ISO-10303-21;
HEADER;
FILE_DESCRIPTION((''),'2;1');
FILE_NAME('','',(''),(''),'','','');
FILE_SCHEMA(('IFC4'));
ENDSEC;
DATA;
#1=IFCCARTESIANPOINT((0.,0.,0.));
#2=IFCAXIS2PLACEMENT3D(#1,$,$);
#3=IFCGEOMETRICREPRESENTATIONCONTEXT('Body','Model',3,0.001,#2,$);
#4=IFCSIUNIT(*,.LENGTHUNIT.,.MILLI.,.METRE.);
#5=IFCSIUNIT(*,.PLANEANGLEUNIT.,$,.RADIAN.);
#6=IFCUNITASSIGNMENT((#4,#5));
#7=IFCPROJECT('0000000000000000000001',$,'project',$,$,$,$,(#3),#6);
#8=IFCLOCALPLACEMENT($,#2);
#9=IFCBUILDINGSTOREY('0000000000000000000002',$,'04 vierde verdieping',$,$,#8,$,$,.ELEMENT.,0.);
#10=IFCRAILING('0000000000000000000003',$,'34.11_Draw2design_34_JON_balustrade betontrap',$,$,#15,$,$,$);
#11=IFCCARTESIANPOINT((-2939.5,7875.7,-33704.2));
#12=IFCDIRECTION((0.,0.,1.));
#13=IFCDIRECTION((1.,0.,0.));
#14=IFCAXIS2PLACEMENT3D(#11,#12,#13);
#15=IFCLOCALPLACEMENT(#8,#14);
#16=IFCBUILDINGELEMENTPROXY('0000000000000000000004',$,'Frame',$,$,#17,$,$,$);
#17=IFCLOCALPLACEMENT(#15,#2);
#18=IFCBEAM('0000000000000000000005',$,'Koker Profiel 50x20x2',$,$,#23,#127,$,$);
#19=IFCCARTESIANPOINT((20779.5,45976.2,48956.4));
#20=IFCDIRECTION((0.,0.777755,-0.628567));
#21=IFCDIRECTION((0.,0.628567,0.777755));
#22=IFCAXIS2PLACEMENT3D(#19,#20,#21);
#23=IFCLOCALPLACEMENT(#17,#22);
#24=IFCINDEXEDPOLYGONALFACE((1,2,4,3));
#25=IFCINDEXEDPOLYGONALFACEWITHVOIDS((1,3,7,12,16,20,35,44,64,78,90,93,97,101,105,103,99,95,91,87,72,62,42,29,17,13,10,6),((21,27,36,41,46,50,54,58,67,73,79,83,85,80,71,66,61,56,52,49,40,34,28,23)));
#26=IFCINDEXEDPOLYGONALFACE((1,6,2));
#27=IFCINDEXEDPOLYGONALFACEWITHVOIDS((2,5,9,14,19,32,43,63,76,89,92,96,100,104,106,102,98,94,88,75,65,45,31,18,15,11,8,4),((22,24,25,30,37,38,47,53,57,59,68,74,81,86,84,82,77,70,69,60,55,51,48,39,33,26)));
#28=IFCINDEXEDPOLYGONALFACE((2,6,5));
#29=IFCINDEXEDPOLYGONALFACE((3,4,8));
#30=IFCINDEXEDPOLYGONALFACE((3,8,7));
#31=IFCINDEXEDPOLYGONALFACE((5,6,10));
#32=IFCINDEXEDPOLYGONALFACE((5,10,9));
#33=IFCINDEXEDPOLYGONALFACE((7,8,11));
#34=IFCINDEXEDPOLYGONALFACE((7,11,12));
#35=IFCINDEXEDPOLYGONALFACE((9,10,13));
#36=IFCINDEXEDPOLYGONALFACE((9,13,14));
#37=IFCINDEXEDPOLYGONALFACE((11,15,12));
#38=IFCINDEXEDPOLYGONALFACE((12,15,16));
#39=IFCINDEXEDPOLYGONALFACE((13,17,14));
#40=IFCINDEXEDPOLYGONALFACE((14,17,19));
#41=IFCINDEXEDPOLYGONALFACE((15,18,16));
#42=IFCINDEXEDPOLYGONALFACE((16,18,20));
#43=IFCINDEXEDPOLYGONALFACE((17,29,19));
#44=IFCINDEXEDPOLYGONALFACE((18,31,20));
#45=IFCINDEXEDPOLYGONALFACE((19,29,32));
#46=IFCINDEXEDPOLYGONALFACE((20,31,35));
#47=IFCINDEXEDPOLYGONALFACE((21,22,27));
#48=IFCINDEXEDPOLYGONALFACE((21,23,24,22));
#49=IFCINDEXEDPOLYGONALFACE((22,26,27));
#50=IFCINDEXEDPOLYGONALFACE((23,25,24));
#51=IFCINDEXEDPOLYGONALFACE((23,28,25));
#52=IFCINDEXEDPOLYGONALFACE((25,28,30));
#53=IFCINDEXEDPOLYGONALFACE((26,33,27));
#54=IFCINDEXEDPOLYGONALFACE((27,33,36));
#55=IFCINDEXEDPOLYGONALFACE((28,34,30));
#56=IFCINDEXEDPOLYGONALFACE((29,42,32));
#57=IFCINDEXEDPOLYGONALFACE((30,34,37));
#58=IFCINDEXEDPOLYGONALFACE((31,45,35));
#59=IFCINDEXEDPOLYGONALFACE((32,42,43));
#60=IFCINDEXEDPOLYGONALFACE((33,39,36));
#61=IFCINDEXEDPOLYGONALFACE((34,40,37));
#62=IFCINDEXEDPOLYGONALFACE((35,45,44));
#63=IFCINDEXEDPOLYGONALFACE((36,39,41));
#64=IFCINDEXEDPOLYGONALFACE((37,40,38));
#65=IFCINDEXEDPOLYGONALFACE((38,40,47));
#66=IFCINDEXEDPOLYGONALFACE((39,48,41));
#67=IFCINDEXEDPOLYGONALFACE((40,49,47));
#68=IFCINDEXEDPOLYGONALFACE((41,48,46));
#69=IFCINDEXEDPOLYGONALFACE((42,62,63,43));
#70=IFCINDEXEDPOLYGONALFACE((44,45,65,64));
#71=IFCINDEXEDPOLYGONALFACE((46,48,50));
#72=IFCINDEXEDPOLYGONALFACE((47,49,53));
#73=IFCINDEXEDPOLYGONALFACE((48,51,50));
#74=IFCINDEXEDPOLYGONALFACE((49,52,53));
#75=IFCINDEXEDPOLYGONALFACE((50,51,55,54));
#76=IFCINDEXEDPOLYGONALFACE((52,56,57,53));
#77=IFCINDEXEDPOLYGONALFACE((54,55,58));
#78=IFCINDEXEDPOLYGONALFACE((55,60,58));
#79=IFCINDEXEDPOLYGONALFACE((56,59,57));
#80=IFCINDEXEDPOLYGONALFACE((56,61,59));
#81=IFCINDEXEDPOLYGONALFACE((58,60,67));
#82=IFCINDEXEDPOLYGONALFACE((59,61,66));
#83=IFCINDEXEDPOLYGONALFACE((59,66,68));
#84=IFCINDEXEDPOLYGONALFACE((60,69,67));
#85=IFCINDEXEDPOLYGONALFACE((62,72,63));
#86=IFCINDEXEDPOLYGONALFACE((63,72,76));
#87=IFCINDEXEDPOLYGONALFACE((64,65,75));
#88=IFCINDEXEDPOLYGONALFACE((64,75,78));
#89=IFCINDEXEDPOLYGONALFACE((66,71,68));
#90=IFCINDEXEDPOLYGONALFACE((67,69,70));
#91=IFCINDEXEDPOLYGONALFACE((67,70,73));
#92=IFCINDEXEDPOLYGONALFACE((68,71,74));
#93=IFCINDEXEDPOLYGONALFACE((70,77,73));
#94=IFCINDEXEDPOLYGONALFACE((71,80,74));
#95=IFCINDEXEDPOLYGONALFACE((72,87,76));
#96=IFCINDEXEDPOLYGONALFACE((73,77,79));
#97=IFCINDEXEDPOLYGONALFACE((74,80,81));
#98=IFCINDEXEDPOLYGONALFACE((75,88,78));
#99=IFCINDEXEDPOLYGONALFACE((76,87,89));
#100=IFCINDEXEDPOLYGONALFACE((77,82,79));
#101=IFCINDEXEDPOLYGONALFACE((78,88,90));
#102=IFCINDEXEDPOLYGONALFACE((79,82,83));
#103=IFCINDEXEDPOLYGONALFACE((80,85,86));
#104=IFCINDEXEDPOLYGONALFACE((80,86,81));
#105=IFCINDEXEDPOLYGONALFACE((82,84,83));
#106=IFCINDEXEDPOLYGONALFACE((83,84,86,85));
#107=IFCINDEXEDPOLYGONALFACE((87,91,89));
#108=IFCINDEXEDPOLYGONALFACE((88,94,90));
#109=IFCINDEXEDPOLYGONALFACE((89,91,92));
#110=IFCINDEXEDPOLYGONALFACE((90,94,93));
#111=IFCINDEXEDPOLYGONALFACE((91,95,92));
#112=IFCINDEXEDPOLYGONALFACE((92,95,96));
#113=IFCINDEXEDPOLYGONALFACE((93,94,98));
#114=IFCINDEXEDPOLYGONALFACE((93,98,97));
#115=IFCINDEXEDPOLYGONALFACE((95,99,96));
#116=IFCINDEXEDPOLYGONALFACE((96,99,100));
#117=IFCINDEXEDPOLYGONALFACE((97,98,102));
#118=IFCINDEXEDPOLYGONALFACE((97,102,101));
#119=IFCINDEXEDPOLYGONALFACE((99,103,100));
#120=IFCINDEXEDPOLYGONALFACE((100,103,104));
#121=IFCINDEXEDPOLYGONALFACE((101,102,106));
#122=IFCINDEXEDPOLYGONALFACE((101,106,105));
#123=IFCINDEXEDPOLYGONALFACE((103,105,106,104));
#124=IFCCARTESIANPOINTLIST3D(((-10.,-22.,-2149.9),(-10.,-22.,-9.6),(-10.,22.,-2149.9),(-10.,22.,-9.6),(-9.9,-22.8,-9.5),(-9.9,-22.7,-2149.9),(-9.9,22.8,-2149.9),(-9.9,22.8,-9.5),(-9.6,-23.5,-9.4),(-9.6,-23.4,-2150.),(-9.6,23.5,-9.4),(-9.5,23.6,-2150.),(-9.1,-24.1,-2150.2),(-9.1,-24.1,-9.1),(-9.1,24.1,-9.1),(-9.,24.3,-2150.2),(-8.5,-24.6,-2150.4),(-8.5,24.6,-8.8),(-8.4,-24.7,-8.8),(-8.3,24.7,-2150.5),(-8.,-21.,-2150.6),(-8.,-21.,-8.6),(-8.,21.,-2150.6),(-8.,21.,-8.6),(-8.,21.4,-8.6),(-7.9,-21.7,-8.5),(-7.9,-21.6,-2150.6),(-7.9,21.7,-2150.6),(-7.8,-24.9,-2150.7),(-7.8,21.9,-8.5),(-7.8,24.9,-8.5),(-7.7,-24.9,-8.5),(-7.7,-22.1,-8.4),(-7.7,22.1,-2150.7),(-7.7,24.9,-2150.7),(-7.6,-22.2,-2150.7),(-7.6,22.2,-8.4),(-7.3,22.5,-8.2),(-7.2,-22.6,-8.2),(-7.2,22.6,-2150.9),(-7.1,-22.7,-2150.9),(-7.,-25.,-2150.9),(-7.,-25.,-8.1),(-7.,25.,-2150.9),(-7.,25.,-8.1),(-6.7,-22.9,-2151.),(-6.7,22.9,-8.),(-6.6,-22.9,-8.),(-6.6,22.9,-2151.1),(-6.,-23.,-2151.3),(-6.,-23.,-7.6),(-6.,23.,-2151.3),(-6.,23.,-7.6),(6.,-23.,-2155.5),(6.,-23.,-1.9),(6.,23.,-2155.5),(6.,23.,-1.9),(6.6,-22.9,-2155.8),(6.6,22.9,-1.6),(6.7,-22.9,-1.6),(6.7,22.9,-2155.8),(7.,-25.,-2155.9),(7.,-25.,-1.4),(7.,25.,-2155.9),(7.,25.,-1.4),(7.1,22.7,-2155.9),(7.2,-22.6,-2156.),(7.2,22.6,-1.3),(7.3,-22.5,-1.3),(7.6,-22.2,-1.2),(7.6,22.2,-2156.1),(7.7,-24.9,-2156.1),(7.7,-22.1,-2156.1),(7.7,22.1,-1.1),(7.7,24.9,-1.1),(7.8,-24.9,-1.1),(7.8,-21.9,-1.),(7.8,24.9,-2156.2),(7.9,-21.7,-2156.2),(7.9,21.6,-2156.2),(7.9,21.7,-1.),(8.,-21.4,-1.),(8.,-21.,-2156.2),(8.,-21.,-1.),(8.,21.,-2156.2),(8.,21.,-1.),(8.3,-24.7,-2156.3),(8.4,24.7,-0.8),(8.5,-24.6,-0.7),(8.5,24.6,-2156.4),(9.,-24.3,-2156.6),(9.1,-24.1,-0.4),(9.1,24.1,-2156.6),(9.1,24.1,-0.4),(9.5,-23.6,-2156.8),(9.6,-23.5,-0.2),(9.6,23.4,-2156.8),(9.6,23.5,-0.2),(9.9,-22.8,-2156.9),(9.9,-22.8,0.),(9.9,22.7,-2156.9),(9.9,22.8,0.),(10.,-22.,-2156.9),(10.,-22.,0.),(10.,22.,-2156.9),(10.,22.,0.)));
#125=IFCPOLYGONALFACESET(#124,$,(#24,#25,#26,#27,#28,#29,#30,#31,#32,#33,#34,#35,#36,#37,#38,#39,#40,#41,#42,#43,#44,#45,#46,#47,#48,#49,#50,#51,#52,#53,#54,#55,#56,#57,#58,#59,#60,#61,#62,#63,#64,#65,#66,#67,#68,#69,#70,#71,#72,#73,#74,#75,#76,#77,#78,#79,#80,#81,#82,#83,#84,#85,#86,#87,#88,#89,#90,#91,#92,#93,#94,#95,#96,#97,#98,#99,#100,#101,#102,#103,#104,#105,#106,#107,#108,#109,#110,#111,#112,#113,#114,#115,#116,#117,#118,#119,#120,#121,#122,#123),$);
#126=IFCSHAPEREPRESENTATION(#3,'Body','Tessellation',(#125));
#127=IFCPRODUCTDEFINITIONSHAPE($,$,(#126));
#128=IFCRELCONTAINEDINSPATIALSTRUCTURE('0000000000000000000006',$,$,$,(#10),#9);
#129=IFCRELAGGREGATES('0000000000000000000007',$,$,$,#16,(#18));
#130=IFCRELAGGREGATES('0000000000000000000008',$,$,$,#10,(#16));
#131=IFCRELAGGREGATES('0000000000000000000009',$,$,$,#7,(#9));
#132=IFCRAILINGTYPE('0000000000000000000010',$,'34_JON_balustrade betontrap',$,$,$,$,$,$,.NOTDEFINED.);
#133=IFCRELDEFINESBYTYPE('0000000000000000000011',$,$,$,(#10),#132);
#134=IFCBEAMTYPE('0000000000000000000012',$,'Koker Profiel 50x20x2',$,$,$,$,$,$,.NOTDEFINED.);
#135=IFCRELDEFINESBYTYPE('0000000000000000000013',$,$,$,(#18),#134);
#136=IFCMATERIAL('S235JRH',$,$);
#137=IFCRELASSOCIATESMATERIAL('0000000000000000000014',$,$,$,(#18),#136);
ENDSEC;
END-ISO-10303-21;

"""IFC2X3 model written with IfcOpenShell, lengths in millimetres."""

from ifc_helpers import new_model, si_unit, frame, origin, origin_2d, place, context, project, spatial, hollow_rectangle, extrude, clip, halfspace, source, transform, mapped, material, type_object, element, aggregate, save


model = new_model("IFC2X3")

# Units and contexts
model_context = context("Model", 3, precision=0.001, world=origin(), identifier="Body")
ifc_project = project(units=[si_unit("LENGTHUNIT", "METRE", prefix="MILLI"), si_unit("PLANEANGLEUNIT", "RADIAN")], contexts=[model_context])

# Storey
storey_placement = place(None, origin())
storey = spatial("IfcBuildingStorey", under=ifc_project, at=storey_placement, Name="04 vierde verdieping", CompositionType="ELEMENT", Elevation=0.0)

# Railing, building element proxy, beam
railing_type = type_object("IfcRailingType", Name="34_JON_balustrade betontrap")
railing_1_placement = place(storey_placement, frame((-2939.5, 7875.7, -33704.2), z_axis=(0.0, 0.0, 1.0), x_axis=(1.0, 0.0, 0.0)))
railing_1 = element("IfcRailing", 1, at=railing_1_placement, inside=storey, type_object=railing_type, Name="34.11_Draw2design_34_JON_balustrade betontrap")
ifc_material_1 = material(Name="S235JRH")
proxy_1_placement = place(railing_1_placement, origin())
proxy_1 = element("IfcBuildingElementProxy", 2, at=proxy_1_placement, Name="Frame")
beam_type_1 = type_object("IfcBeamType", Name="Koker Profiel 50x20x2")
shared_shape_1 = source(origin(), model_context, "Body", "Clipping", [
    clip(clip(extrude(hollow_rectangle(XDim=20.0, YDim=50.0, WallThickness=2.0, InnerFilletRadius=2.0, OuterFilletRadius=3.0, at=origin_2d()), origin(), (0.0, 0.0, -1.0), 2156.9), halfspace(frame((-10.0, 25.0, -9.6), z_axis=(-0.430948, 0.0, 0.902377), x_axis=(-0.902377, 0.0, -0.430948)), False)), halfspace(frame((-10.0, -25.0, -2149.9), z_axis=(-0.33335, 0.0, -0.942803), x_axis=(0.0, -1.0, 0.0)), False)),
])
beam_1_placement = place(proxy_1_placement, frame((20779.5, 45976.2, 48956.4), z_axis=(0.0, 0.777755, -0.628567), x_axis=(0.0, 0.628567, 0.777755)))
beam_1 = element("IfcBeam", 3, at=beam_1_placement, type_object=beam_type_1, material=ifc_material_1, Name="Koker Profiel 50x20x2", context=model_context, shape_type="MappedRepresentation", body=[
    mapped(shared_shape_1, transform((0.0, 0.0, 0.0), scale=1.0)),
])

aggregate(proxy_1, [beam_1])

aggregate(railing_1, [proxy_1])

save(model, "model.ifc")
